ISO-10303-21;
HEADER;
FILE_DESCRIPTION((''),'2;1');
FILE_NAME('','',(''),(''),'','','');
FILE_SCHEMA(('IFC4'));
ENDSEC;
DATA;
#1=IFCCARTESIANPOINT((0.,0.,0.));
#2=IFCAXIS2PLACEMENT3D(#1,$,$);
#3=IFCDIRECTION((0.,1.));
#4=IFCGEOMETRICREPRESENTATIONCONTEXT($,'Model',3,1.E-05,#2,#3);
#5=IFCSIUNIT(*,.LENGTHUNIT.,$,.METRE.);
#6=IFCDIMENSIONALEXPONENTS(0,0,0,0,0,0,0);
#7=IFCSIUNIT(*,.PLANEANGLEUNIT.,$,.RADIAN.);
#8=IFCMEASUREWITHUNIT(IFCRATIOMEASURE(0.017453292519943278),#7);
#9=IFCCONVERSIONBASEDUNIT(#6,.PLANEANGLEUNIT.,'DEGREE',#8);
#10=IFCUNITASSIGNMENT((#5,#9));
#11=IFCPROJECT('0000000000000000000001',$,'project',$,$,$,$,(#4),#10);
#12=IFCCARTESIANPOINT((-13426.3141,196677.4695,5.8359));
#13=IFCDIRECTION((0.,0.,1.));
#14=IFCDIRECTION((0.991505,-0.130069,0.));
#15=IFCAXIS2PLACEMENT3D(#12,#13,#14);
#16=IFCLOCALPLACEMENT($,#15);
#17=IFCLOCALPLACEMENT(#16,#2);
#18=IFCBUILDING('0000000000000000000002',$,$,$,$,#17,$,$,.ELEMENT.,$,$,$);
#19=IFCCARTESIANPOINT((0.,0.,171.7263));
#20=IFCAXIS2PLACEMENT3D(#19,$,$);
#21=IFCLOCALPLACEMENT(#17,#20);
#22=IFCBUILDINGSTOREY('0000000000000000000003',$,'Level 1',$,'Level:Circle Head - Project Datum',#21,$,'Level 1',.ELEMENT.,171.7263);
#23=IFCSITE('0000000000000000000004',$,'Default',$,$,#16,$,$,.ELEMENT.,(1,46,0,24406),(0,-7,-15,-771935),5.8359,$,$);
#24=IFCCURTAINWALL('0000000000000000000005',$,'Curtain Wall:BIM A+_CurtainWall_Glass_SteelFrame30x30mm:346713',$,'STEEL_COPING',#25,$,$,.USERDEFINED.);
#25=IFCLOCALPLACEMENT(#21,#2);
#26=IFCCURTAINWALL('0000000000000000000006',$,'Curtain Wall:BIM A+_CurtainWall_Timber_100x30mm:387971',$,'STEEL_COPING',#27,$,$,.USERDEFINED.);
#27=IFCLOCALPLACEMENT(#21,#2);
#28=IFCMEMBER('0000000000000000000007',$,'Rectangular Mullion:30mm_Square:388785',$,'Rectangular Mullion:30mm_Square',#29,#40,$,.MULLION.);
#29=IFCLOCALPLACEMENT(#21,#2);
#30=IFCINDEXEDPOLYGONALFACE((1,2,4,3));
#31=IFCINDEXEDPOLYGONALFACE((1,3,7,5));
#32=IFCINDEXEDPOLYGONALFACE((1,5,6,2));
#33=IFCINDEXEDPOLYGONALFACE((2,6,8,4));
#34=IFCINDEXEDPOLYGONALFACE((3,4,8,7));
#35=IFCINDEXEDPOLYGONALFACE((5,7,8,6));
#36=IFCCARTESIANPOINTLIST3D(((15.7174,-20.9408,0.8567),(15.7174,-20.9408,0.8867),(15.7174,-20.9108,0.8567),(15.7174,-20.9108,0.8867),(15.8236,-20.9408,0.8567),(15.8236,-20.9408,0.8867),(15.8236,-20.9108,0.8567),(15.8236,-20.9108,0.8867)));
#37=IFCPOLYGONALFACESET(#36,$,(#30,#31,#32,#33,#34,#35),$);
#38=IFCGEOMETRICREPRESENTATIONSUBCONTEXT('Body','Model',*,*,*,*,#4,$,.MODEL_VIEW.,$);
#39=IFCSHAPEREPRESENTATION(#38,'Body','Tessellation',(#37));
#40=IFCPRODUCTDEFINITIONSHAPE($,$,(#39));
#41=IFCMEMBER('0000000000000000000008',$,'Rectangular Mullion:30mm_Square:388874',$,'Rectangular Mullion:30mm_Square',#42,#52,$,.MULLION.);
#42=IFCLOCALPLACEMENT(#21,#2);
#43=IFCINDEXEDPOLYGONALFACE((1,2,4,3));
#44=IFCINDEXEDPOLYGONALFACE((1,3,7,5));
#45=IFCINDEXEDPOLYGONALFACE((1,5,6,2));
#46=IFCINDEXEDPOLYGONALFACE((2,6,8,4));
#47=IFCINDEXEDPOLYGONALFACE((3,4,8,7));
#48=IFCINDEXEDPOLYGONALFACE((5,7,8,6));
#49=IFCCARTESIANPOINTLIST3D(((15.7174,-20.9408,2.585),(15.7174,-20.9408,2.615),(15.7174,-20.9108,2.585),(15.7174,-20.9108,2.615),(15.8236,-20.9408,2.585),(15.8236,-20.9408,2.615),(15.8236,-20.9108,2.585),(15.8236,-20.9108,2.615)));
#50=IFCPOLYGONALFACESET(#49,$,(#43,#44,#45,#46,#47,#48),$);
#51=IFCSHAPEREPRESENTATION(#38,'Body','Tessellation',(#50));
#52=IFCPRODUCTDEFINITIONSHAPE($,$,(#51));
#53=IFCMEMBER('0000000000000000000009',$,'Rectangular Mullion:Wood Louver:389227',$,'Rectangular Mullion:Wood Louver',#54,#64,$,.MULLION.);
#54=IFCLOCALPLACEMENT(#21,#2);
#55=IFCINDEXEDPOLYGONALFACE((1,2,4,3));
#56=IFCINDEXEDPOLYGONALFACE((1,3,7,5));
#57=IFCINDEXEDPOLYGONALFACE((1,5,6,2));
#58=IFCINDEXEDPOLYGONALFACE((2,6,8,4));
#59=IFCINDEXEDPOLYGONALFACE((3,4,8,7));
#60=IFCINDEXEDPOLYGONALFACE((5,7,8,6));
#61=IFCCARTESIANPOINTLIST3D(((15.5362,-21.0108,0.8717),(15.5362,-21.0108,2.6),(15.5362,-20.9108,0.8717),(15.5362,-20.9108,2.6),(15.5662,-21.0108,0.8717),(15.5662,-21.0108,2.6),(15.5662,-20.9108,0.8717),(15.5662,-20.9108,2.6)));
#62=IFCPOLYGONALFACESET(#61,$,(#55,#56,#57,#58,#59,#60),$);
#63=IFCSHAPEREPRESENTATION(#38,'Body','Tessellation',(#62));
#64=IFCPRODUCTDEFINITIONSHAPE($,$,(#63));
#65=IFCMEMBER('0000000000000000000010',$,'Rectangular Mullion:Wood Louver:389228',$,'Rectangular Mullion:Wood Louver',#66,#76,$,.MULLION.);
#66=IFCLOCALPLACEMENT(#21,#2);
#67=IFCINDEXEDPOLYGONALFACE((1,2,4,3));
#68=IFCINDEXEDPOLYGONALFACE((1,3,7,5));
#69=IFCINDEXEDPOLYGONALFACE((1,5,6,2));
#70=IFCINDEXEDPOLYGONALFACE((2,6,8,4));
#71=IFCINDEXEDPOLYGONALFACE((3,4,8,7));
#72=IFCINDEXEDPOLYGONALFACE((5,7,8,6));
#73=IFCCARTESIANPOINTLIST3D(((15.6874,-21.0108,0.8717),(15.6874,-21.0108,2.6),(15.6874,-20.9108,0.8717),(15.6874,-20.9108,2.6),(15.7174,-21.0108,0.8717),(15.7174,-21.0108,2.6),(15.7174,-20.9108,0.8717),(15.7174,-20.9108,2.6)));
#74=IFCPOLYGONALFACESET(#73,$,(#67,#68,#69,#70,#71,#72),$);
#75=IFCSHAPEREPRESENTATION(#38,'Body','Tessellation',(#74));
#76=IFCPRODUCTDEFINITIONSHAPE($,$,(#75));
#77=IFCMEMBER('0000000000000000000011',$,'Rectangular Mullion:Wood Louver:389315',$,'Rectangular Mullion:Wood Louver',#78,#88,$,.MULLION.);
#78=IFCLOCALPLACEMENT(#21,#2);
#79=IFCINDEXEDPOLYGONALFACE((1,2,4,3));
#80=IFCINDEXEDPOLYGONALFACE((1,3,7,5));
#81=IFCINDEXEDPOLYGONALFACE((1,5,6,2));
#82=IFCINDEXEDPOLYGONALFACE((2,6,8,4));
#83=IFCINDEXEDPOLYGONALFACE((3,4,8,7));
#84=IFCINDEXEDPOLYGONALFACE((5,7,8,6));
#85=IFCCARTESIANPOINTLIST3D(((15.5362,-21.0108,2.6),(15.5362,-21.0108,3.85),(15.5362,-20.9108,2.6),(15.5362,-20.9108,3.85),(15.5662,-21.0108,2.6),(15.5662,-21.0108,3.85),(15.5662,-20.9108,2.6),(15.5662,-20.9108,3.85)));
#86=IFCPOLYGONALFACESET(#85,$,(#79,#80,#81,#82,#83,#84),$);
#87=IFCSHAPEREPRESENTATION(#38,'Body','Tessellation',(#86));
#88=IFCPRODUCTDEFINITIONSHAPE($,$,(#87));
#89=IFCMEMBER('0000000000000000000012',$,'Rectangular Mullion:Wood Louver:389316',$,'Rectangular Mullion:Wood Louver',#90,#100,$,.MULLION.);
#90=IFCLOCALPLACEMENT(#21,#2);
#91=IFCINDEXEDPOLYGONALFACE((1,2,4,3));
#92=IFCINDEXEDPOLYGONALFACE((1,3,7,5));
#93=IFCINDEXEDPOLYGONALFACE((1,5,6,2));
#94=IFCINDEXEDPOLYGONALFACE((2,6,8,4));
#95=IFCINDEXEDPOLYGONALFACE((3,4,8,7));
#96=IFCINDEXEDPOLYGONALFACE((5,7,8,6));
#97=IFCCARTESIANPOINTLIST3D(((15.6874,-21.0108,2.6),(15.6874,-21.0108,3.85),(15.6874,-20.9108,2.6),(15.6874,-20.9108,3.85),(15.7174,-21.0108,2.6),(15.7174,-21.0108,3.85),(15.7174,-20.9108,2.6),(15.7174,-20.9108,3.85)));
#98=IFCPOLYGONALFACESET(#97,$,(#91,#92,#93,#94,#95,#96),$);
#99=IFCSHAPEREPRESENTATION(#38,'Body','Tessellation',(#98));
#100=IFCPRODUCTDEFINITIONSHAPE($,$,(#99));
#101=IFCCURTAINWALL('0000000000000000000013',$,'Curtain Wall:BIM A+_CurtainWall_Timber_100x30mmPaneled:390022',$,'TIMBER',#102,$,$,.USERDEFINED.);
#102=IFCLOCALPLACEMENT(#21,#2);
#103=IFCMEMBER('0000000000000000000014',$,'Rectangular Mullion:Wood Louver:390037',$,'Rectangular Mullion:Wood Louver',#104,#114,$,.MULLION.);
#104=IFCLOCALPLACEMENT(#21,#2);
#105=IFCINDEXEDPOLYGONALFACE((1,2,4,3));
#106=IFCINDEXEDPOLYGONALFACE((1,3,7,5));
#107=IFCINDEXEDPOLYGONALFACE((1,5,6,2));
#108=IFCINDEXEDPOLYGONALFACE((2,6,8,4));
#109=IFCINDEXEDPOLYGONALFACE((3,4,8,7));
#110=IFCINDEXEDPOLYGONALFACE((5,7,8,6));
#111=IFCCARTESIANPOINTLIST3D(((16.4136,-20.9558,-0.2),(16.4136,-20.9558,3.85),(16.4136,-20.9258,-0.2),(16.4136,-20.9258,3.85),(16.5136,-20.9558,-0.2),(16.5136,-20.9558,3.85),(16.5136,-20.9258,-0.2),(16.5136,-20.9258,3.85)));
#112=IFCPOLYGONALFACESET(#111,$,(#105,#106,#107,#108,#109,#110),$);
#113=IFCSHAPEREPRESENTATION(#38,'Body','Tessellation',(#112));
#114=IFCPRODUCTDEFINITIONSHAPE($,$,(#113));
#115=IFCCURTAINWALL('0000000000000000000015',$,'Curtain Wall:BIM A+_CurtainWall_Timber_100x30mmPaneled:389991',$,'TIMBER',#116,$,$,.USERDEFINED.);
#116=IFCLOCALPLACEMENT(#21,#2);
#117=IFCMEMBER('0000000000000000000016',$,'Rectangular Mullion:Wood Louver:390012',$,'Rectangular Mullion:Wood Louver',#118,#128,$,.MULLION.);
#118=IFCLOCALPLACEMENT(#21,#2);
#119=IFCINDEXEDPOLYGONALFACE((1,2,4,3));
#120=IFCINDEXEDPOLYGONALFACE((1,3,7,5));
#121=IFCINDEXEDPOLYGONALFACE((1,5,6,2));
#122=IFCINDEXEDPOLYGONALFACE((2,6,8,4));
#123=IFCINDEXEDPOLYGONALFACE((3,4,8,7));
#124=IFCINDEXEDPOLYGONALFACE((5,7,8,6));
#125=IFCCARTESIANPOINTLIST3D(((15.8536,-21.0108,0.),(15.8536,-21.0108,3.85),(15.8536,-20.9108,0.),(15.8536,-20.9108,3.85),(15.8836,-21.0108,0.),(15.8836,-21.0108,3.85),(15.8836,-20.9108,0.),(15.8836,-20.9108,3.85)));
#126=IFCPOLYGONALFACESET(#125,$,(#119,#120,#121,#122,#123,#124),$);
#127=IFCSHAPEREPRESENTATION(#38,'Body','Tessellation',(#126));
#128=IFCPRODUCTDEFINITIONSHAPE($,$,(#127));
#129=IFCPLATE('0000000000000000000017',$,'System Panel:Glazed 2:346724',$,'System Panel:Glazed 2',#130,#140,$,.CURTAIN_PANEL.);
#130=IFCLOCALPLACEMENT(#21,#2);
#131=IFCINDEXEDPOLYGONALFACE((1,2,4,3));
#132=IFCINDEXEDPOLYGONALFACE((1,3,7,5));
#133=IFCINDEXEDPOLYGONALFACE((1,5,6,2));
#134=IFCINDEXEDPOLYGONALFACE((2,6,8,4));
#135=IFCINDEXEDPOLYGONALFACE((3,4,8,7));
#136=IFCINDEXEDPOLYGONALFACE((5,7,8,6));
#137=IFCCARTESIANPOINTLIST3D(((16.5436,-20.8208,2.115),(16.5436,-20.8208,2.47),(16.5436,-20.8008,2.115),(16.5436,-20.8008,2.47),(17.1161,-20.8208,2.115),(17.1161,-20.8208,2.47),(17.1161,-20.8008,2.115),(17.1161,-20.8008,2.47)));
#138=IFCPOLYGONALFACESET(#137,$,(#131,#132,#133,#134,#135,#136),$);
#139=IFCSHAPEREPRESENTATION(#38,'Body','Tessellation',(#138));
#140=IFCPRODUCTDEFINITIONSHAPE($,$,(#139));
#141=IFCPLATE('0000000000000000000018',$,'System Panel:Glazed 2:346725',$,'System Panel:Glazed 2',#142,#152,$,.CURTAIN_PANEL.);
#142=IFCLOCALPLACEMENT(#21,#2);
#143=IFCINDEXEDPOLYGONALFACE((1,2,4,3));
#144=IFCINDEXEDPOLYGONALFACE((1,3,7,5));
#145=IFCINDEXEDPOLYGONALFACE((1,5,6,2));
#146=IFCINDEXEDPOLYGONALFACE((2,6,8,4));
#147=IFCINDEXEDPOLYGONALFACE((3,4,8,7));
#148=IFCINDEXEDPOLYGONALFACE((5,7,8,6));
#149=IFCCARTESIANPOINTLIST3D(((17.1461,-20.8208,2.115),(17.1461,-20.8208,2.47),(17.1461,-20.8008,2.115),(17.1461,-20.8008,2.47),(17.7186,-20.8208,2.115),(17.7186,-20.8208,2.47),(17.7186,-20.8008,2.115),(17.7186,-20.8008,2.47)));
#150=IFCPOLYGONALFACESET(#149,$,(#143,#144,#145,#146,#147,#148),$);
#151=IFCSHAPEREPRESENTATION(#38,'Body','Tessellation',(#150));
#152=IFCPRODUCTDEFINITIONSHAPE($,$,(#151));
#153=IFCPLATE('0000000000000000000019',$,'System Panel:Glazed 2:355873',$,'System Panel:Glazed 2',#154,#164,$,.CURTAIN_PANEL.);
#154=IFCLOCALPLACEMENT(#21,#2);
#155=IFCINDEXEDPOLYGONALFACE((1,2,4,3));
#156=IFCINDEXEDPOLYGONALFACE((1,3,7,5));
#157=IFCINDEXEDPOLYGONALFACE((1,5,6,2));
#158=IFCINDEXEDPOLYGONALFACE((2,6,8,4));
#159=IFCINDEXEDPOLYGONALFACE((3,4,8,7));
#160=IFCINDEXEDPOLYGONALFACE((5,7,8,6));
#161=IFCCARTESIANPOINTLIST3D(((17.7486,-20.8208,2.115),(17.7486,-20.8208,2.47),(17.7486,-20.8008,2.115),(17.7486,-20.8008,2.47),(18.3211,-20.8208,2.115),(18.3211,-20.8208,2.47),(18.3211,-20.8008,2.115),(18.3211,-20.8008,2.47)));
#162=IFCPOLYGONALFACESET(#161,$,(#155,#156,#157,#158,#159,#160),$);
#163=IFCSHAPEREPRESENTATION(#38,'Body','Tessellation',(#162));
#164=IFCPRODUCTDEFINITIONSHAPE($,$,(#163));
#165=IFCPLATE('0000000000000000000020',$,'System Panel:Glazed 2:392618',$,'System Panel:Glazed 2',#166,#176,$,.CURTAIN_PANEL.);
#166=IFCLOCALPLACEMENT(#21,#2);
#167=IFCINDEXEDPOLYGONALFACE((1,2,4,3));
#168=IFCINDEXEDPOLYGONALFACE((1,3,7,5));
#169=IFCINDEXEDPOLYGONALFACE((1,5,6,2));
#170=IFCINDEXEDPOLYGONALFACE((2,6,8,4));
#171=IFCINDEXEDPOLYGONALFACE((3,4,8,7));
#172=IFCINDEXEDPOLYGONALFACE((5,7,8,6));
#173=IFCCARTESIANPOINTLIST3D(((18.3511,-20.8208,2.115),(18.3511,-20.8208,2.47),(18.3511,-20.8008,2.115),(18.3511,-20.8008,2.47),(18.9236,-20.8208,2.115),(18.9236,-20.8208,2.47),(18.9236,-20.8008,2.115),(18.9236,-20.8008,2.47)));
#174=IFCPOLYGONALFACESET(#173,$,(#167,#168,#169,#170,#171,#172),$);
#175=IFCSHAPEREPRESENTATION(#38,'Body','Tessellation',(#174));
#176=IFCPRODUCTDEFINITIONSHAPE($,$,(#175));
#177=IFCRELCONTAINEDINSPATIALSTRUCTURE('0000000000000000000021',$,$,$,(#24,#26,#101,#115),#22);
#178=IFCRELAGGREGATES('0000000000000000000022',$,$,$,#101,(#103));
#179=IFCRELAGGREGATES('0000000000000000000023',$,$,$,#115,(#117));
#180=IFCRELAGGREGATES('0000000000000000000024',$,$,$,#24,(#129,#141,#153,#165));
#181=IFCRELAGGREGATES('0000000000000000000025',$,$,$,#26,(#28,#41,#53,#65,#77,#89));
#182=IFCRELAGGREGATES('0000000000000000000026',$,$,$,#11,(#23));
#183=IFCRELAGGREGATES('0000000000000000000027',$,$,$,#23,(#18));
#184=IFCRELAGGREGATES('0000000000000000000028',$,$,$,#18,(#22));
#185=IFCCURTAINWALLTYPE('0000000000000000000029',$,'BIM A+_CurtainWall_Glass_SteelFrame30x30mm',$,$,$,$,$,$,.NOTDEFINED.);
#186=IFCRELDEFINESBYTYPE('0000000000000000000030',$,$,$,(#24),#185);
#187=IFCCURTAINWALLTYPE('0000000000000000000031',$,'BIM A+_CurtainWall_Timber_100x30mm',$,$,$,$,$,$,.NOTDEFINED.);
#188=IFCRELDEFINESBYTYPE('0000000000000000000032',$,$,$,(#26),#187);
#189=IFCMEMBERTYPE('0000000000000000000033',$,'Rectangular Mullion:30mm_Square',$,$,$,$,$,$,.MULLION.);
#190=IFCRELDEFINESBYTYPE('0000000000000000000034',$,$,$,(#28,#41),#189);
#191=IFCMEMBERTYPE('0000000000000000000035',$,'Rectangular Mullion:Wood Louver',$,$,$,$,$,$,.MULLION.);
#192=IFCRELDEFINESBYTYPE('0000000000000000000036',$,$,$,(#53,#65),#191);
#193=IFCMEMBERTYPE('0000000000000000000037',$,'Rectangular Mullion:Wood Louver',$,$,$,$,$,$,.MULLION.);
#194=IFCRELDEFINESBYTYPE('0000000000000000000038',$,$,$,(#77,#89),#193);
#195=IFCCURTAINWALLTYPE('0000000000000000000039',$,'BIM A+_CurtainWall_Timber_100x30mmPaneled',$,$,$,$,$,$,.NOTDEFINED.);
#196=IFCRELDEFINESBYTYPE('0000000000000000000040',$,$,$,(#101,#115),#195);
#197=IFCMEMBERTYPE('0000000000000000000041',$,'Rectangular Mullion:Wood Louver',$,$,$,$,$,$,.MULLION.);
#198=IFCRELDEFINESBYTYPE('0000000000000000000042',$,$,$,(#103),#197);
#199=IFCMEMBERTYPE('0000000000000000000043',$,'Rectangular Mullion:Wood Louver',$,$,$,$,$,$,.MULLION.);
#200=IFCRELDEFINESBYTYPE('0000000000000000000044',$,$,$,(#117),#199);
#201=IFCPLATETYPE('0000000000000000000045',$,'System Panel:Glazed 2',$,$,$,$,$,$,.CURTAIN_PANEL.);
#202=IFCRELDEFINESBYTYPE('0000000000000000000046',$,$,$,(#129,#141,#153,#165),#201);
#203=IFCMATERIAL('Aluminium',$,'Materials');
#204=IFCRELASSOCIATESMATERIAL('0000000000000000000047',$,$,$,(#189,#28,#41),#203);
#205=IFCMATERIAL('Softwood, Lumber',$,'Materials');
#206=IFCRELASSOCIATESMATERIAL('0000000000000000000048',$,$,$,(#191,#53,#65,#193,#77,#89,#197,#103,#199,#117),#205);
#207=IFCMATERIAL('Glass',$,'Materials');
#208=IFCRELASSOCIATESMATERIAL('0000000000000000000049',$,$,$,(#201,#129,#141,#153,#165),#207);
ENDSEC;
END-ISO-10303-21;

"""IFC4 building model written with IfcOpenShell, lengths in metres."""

from ifc_helpers import new_model, entity, si_unit, converted_unit, direction, frame, origin, place, context, subcontext, project, spatial, indexed_curve, outline, extrude, source, transform, mapped, material, type_object, type_shapes, element, aggregate, save


model = new_model("IFC4")

# Units and contexts
model_context = context("Model", 3, precision=1e-05, world=origin(), true_north=direction((0.0, 1.0)))
body_context = subcontext(model_context, "Body", "Model", "MODEL_VIEW")
ifc_project = project(units=[si_unit("LENGTHUNIT", "METRE"), converted_unit("PLANEANGLEUNIT", "DEGREE", entity("IfcRatioMeasure", 0.017453292519943278), si_unit("PLANEANGLEUNIT", "RADIAN"), dimensions=[0, 0, 0, 0, 0, 0, 0])], contexts=[model_context])

# Site, building, storey
site_placement = place(None, frame((-13426.3141, 196677.4695, 5.8359), z_axis=(0.0, 0.0, 1.0), x_axis=(0.991505, -0.130069, 0.0)))
site = spatial("IfcSite", under=ifc_project, at=site_placement, Name="Default", CompositionType="ELEMENT", RefLatitude=(1, 46, 0, 24406), RefLongitude=(0, -7, -15, -771935), RefElevation=5.8359)
building_placement = place(site_placement, origin())
building = spatial("IfcBuilding", under=site, at=building_placement, CompositionType="ELEMENT")
storey_placement = place(building_placement, frame((0.0, 0.0, 171.7263)))
storey = spatial("IfcBuildingStorey", under=building, at=storey_placement, Name="Level 1", ObjectType="Level:Circle Head - Project Datum", LongName="Level 1", CompositionType="ELEMENT", Elevation=171.7263)

# Curtain walls, members
curtain_wall_type_1 = type_object("IfcCurtainWallType", Name="BIM A+_CurtainWall_Glass_SteelFrame30x30mm", PredefinedType="NOTDEFINED")
curtain_wall_1_placement = place(storey_placement, frame((0.0, 0.0, -171.7263)))
curtain_wall_1 = element("IfcCurtainWall", 1, at=curtain_wall_1_placement, inside=storey, type_object=curtain_wall_type_1, Name="Curtain Wall:BIM A+_CurtainWall_Glass_SteelFrame30x30mm:346713", ObjectType="STEEL_COPING", PredefinedType="USERDEFINED")
ifc_material_1 = material(Name="Aluminium", Category="Materials")
curtain_wall_type_2 = type_object("IfcCurtainWallType", Name="BIM A+_CurtainWall_Timber_100x30mm", PredefinedType="NOTDEFINED")
curtain_wall_2_placement = place(storey_placement, frame((0.0, 0.0, -171.7263)))
curtain_wall_2 = element("IfcCurtainWall", 2, at=curtain_wall_2_placement, inside=storey, type_object=curtain_wall_type_2, Name="Curtain Wall:BIM A+_CurtainWall_Timber_100x30mm:387971", ObjectType="STEEL_COPING", PredefinedType="USERDEFINED")
ifc_material_2 = material(Name="Softwood, Lumber", Category="Materials")
member_type_1 = type_object("IfcMemberType", Name="Rectangular Mullion:30mm_Square", PredefinedType="MULLION", material=ifc_material_1)
shared_shape_1 = source(origin(), body_context, "Body", "SweptSolid", [
    extrude(outline(indexed_curve([(-0.015, -0.015), (0.015, -0.015), (0.015, 0.015), (-0.015, 0.015), (-0.015, -0.015)], self_intersect=False)), frame((0.0, 0.0, -0.1062), z_axis=(0.0, 0.0, 1.0), x_axis=(0.0, -1.0, 0.0)), (0.0, 0.0, 1.0), 0.1062),
])
type_shapes(member_type_1, [shared_shape_1])
member_1_placement = place(curtain_wall_2_placement, frame((15.8236, -20.9258, 172.598), z_axis=(1.0, 0.0, 0.0), x_axis=(0.0, 0.0, 1.0)))
member_1 = element("IfcMember", 3, at=member_1_placement, type_object=member_type_1, material=ifc_material_1, Name="Rectangular Mullion:30mm_Square:388785", ObjectType="Rectangular Mullion:30mm_Square", PredefinedType="MULLION", context=body_context, shape_type="MappedRepresentation", body=[
    mapped(shared_shape_1, transform((0.0, 0.0, 0.0), scale=1.0)),
])
member_2_placement = place(curtain_wall_2_placement, frame((15.8236, -20.9258, 174.3263), z_axis=(1.0, 0.0, 0.0), x_axis=(0.0, 0.0, 1.0)))
member_2 = element("IfcMember", 4, at=member_2_placement, type_object=member_type_1, material=ifc_material_1, Name="Rectangular Mullion:30mm_Square:388874", ObjectType="Rectangular Mullion:30mm_Square", PredefinedType="MULLION", context=body_context, shape_type="MappedRepresentation", body=[
    mapped(shared_shape_1, transform((0.0, 0.0, 0.0), scale=1.0)),
])
member_type_2 = type_object("IfcMemberType", Name="Rectangular Mullion:Wood Louver", PredefinedType="MULLION", material=ifc_material_2)
shared_shape_2 = source(origin(), body_context, "Body", "SweptSolid", [
    extrude(outline(indexed_curve([(-0.05, -0.015), (0.05, -0.015), (0.05, 0.015), (-0.05, 0.015), (-0.05, -0.015)], self_intersect=False)), frame((0.0, 0.035, -1.7283), z_axis=(0.0, 0.0, 1.0), x_axis=(0.0, -1.0, 0.0)), (0.0, 0.0, 1.0), 1.7283),
])
type_shapes(member_type_2, [shared_shape_2])
member_3_placement = place(curtain_wall_2_placement, frame((15.5512, -20.9258, 172.598), z_axis=(0.0, 0.0, -1.0), x_axis=(1.0, 0.0, 0.0)))
member_3 = element("IfcMember", 5, at=member_3_placement, type_object=member_type_2, material=ifc_material_2, Name="Rectangular Mullion:Wood Louver:389227", ObjectType="Rectangular Mullion:Wood Louver", PredefinedType="MULLION", context=body_context, shape_type="MappedRepresentation", body=[
    mapped(shared_shape_2, transform((0.0, 0.0, 0.0), scale=1.0)),
])
member_4_placement = place(curtain_wall_2_placement, frame((15.7024, -20.9258, 172.598), z_axis=(0.0, 0.0, -1.0), x_axis=(1.0, 0.0, 0.0)))
member_4 = element("IfcMember", 6, at=member_4_placement, type_object=member_type_2, material=ifc_material_2, Name="Rectangular Mullion:Wood Louver:389228", ObjectType="Rectangular Mullion:Wood Louver", PredefinedType="MULLION", context=body_context, shape_type="MappedRepresentation", body=[
    mapped(shared_shape_2, transform((0.0, 0.0, 0.0), scale=1.0)),
])
member_type_3 = type_object("IfcMemberType", Name="Rectangular Mullion:Wood Louver", PredefinedType="MULLION", material=ifc_material_2)
shared_shape_3 = source(origin(), body_context, "Body", "SweptSolid", [
    extrude(outline(indexed_curve([(-0.05, -0.015), (0.05, -0.015), (0.05, 0.015), (-0.05, 0.015), (-0.05, -0.015)], self_intersect=False)), frame((0.0, 0.035, -1.25), z_axis=(0.0, 0.0, 1.0), x_axis=(0.0, -1.0, 0.0)), (0.0, 0.0, 1.0), 1.25),
])
type_shapes(member_type_3, [shared_shape_3])
member_5_placement = place(curtain_wall_2_placement, frame((15.5512, -20.9258, 174.3263), z_axis=(0.0, 0.0, -1.0), x_axis=(1.0, 0.0, 0.0)))
member_5 = element("IfcMember", 7, at=member_5_placement, type_object=member_type_3, material=ifc_material_2, Name="Rectangular Mullion:Wood Louver:389315", ObjectType="Rectangular Mullion:Wood Louver", PredefinedType="MULLION", context=body_context, shape_type="MappedRepresentation", body=[
    mapped(shared_shape_3, transform((0.0, 0.0, 0.0), scale=1.0)),
])
member_6_placement = place(curtain_wall_2_placement, frame((15.7024, -20.9258, 174.3263), z_axis=(0.0, 0.0, -1.0), x_axis=(1.0, 0.0, 0.0)))
member_6 = element("IfcMember", 8, at=member_6_placement, type_object=member_type_3, material=ifc_material_2, Name="Rectangular Mullion:Wood Louver:389316", ObjectType="Rectangular Mullion:Wood Louver", PredefinedType="MULLION", context=body_context, shape_type="MappedRepresentation", body=[
    mapped(shared_shape_3, transform((0.0, 0.0, 0.0), scale=1.0)),
])

# Curtain walls, members
curtain_wall_type_3 = type_object("IfcCurtainWallType", Name="BIM A+_CurtainWall_Timber_100x30mmPaneled", PredefinedType="NOTDEFINED")
curtain_wall_3_placement = place(storey_placement, frame((0.0, 0.0, -171.7263)))
curtain_wall_3 = element("IfcCurtainWall", 9, at=curtain_wall_3_placement, inside=storey, type_object=curtain_wall_type_3, Name="Curtain Wall:BIM A+_CurtainWall_Timber_100x30mmPaneled:390022", ObjectType="TIMBER", PredefinedType="USERDEFINED")
member_type_4 = type_object("IfcMemberType", Name="Rectangular Mullion:Wood Louver", PredefinedType="MULLION", material=ifc_material_2)
shared_shape_4 = source(origin(), body_context, "Body", "SweptSolid", [
    extrude(outline(indexed_curve([(-0.05, -0.015), (0.05, -0.015), (0.05, 0.015), (-0.05, 0.015), (-0.05, -0.015)], self_intersect=False)), frame((-0.015, -0.035, -4.05), z_axis=(0.0, 0.0, 1.0), x_axis=(0.0, -1.0, 0.0)), (0.0, 0.0, 1.0), 4.05),
])
type_shapes(member_type_4, [shared_shape_4])
member_7_placement = place(curtain_wall_3_placement, frame((16.4986, -20.9558, 175.5763), z_axis=(0.0, 0.0, 1.0), x_axis=(0.0, -1.0, 0.0)))
member_7 = element("IfcMember", 10, at=member_7_placement, type_object=member_type_4, material=ifc_material_2, Name="Rectangular Mullion:Wood Louver:390037", ObjectType="Rectangular Mullion:Wood Louver", PredefinedType="MULLION", context=body_context, shape_type="MappedRepresentation", body=[
    mapped(shared_shape_4, transform((0.0, 0.0, 0.0), scale=1.0)),
])
aggregate(curtain_wall_3, [member_7])
curtain_wall_4_placement = place(storey_placement, frame((0.0, 0.0, -171.7263)))
curtain_wall_4 = element("IfcCurtainWall", 11, at=curtain_wall_4_placement, inside=storey, type_object=curtain_wall_type_3, Name="Curtain Wall:BIM A+_CurtainWall_Timber_100x30mmPaneled:389991", ObjectType="TIMBER", PredefinedType="USERDEFINED")
member_type_5 = type_object("IfcMemberType", Name="Rectangular Mullion:Wood Louver", PredefinedType="MULLION", material=ifc_material_2)
shared_shape_5 = source(origin(), body_context, "Body", "SweptSolid", [
    extrude(outline(indexed_curve([(-0.05, -0.015), (0.05, -0.015), (0.05, 0.015), (-0.05, 0.015), (-0.05, -0.015)], self_intersect=False)), frame((-0.015, 0.035, -3.85), z_axis=(0.0, 0.0, 1.0), x_axis=(0.0, -1.0, 0.0)), (0.0, 0.0, 1.0), 3.85),
])
type_shapes(member_type_5, [shared_shape_5])
member_8_placement = place(curtain_wall_4_placement, frame((15.8536, -20.9258, 175.5763), z_axis=(0.0, 0.0, 1.0), x_axis=(-1.0, 0.0, 0.0)))
member_8 = element("IfcMember", 12, at=member_8_placement, type_object=member_type_5, material=ifc_material_2, Name="Rectangular Mullion:Wood Louver:390012", ObjectType="Rectangular Mullion:Wood Louver", PredefinedType="MULLION", context=body_context, shape_type="MappedRepresentation", body=[
    mapped(shared_shape_5, transform((0.0, 0.0, 0.0), scale=1.0)),
])
aggregate(curtain_wall_4, [member_8])

# Plates
ifc_material_3 = material(Name="Glass", Category="Materials")
plate_type_1 = type_object("IfcPlateType", Name="System Panel:Glazed 2", PredefinedType="CURTAIN_PANEL", material=ifc_material_3)
shared_shape_6 = source(origin(), body_context, "Body", "SweptSolid", [
    extrude(outline(indexed_curve([(-0.01, -0.2863), (0.01, -0.2863), (0.01, 0.2863), (-0.01, 0.2863), (-0.01, -0.2863)], self_intersect=False)), frame((0.0, 0.0, 0.0), z_axis=(0.0, 0.0, 1.0), x_axis=(0.0, 1.0, 0.0)), (0.0, 0.0, 1.0), 0.355),
])
type_shapes(plate_type_1, [shared_shape_6])
plate_1_placement = place(curtain_wall_1_placement, frame((16.8298, -20.8108, 173.8413)))
plate_1 = element("IfcPlate", 13, at=plate_1_placement, type_object=plate_type_1, material=ifc_material_3, Name="System Panel:Glazed 2:346724", ObjectType="System Panel:Glazed 2", PredefinedType="CURTAIN_PANEL", context=body_context, shape_type="MappedRepresentation", body=[
    mapped(shared_shape_6, transform((0.0, 0.0, 0.0), scale=1.0)),
])
plate_2_placement = place(curtain_wall_1_placement, frame((17.4323, -20.8108, 173.8413)))
plate_2 = element("IfcPlate", 14, at=plate_2_placement, type_object=plate_type_1, material=ifc_material_3, Name="System Panel:Glazed 2:346725", ObjectType="System Panel:Glazed 2", PredefinedType="CURTAIN_PANEL", context=body_context, shape_type="MappedRepresentation", body=[
    mapped(shared_shape_6, transform((0.0, 0.0, 0.0), scale=1.0)),
])
plate_3_placement = place(curtain_wall_1_placement, frame((18.0348, -20.8108, 173.8413)))
plate_3 = element("IfcPlate", 15, at=plate_3_placement, type_object=plate_type_1, material=ifc_material_3, Name="System Panel:Glazed 2:355873", ObjectType="System Panel:Glazed 2", PredefinedType="CURTAIN_PANEL", context=body_context, shape_type="MappedRepresentation", body=[
    mapped(shared_shape_6, transform((0.0, 0.0, 0.0), scale=1.0)),
])
plate_4_placement = place(curtain_wall_1_placement, frame((18.6373, -20.8108, 173.8413)))
plate_4 = element("IfcPlate", 16, at=plate_4_placement, type_object=plate_type_1, material=ifc_material_3, Name="System Panel:Glazed 2:392618", ObjectType="System Panel:Glazed 2", PredefinedType="CURTAIN_PANEL", context=body_context, shape_type="MappedRepresentation", body=[
    mapped(shared_shape_6, transform((0.0, 0.0, 0.0), scale=1.0)),
])
aggregate(curtain_wall_1, [plate_1, plate_2, plate_3, plate_4])
aggregate(curtain_wall_2, [member_1, member_2, member_3, member_4, member_5, member_6])

save(model, "model.ifc")
